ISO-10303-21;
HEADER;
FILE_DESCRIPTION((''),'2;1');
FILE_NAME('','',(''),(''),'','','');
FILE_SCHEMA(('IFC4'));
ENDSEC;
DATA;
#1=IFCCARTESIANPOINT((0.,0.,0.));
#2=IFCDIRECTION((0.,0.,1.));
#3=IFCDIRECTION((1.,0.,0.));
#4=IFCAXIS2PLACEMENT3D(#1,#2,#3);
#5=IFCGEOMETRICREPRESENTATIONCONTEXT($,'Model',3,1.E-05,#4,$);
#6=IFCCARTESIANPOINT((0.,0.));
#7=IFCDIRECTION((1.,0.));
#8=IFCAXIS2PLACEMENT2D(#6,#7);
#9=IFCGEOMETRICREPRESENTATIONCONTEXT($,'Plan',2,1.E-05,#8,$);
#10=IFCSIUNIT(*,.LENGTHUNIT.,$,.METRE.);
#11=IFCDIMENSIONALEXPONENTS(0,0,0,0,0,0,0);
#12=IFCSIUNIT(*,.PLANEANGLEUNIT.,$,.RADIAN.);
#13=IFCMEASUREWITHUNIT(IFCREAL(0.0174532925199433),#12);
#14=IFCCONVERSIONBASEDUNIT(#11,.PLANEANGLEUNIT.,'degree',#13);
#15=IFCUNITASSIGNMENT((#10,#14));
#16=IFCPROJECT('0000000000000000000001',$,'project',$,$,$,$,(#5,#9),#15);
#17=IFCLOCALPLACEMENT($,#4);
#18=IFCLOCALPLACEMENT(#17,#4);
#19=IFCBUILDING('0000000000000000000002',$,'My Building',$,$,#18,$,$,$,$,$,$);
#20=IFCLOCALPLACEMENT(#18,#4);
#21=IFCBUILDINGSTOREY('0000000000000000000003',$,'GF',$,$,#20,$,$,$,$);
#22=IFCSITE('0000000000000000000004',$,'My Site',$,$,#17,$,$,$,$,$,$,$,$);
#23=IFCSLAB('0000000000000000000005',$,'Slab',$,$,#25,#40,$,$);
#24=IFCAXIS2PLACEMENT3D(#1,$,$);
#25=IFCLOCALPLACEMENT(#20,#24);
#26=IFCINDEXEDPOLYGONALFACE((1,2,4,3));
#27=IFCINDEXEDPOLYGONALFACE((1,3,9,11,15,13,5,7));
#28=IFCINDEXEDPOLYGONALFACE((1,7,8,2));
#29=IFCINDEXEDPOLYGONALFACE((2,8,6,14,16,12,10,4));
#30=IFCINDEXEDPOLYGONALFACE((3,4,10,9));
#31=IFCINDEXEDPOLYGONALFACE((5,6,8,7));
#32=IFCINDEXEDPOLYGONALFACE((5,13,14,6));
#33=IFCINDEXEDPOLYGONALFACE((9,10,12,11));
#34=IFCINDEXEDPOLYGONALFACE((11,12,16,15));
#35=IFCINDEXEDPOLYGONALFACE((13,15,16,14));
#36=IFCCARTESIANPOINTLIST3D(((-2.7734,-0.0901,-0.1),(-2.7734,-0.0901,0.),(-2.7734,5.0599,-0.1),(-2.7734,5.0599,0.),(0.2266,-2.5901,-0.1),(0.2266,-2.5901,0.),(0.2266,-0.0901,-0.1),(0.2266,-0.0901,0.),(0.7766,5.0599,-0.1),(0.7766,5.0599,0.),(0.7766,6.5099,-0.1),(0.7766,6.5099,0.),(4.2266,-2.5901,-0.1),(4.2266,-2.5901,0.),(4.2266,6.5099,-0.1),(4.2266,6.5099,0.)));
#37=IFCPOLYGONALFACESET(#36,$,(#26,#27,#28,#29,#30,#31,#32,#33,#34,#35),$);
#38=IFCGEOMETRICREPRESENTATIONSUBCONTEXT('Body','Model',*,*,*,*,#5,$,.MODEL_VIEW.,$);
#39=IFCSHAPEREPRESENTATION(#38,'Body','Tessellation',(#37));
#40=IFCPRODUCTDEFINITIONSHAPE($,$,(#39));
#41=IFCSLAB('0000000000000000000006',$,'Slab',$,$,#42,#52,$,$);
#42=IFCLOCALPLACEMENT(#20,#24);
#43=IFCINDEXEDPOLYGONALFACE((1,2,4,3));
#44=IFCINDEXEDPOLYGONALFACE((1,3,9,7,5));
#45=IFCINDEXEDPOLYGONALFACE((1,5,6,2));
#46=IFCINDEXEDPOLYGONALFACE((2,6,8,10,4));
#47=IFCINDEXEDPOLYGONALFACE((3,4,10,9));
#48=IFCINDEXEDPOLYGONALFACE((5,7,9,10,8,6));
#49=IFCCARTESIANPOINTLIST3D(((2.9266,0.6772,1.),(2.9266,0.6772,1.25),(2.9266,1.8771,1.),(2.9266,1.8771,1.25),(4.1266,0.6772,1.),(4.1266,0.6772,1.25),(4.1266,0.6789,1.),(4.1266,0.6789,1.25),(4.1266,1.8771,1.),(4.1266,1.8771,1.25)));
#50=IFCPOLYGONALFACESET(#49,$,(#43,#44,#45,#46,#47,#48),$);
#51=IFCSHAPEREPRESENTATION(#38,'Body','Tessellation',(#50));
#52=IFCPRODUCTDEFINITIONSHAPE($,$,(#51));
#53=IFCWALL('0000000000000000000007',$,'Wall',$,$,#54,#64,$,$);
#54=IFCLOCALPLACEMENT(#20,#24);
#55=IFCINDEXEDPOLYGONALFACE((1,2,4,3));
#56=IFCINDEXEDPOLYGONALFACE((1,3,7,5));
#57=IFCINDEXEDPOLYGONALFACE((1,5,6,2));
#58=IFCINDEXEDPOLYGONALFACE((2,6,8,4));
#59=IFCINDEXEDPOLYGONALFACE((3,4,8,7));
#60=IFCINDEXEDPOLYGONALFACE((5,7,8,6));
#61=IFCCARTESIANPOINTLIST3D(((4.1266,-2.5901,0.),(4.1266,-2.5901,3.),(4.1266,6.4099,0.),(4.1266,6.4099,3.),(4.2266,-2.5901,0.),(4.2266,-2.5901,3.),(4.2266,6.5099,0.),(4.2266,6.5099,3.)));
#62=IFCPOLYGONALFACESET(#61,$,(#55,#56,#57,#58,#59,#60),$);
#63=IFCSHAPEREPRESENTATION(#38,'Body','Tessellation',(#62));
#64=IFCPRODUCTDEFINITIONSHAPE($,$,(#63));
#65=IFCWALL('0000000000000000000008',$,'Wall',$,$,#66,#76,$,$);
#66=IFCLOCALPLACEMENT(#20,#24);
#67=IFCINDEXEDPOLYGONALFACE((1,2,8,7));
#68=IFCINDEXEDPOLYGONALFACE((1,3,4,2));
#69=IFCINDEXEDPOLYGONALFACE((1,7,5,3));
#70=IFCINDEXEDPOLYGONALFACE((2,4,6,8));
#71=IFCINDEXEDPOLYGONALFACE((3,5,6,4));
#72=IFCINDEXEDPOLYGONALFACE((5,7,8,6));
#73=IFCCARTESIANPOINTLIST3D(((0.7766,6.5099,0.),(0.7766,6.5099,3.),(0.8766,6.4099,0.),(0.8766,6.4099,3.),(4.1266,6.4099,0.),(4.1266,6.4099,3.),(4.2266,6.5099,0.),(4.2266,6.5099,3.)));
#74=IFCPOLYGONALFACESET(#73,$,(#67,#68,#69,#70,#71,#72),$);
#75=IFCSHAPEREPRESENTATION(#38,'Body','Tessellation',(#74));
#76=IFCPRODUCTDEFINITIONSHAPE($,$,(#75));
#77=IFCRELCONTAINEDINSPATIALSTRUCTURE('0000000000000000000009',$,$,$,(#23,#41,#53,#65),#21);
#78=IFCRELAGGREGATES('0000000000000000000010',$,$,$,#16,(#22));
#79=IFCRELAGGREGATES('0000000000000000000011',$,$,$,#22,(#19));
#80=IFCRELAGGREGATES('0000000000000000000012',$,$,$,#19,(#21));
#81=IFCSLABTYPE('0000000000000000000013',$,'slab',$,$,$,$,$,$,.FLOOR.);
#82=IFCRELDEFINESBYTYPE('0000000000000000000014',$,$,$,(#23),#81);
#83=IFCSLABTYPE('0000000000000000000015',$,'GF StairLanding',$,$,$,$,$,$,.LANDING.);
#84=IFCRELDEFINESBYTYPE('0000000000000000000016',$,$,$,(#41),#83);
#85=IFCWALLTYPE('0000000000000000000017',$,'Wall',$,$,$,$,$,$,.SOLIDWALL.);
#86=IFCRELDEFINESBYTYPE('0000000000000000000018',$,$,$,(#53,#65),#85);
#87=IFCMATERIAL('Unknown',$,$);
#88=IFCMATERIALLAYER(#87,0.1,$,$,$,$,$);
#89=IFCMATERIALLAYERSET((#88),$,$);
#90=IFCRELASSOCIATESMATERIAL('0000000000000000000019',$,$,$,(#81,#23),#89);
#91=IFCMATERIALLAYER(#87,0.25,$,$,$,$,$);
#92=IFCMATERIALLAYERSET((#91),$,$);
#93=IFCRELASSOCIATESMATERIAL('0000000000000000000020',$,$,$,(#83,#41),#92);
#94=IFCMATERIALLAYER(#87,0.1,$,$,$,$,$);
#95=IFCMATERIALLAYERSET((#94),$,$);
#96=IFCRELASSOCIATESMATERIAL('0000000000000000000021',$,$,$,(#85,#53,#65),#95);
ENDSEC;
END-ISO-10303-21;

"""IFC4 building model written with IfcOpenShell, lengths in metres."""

from ifc_helpers import new_model, entity, si_unit, converted_unit, frame, origin_with_axes, origin_2d_with_axis, place, context, subcontext, project, spatial, line, indexed_curve, outline, extrude, material, layer, layer_set, layer_usage, type_object, element, save


model = new_model("IFC4")

# Units and contexts
model_context = context("Model", 3, precision=1e-05, world=origin_with_axes())
plan_context = context("Plan", 2, precision=1e-05, world=origin_2d_with_axis())
body_context_1 = subcontext(model_context, "Body", "Model", "MODEL_VIEW")
ifc_project = project(units=[si_unit("LENGTHUNIT", "METRE"), converted_unit("PLANEANGLEUNIT", "degree", entity("IfcReal", 0.0174532925199433), si_unit("PLANEANGLEUNIT", "RADIAN"), dimensions=[0, 0, 0, 0, 0, 0, 0])], contexts=[model_context, plan_context])

# Site, building, storey
site_placement = place(None, origin_with_axes())
site = spatial("IfcSite", under=ifc_project, at=site_placement, Name="My Site")
building_placement = place(site_placement, origin_with_axes())
building = spatial("IfcBuilding", under=site, at=building_placement, Name="My Building")
storey_placement = place(building_placement, origin_with_axes())
storey = spatial("IfcBuildingStorey", under=building, at=storey_placement, Name="GF")

# Slabs
ifc_material_1 = material(Name="Unknown")
ifc_layer_1 = layer(ifc_material_1, 0.1)
ifc_layer_set_1 = layer_set([ifc_layer_1])
ifc_layer_usage_1 = layer_usage(ifc_layer_set_1, "AXIS3", "POSITIVE", -0.1)
slab_type_1 = type_object("IfcSlabType", Name="slab", PredefinedType="FLOOR", material=ifc_layer_set_1)
slab_1_placement = place(storey_placement, frame((4.2266, -2.5901, 0.0), z_axis=(0.0, 0.0, 1.0), x_axis=(1.0, 0.0, 0.0)))
element("IfcSlab", 1, at=slab_1_placement, inside=storey, type_object=slab_type_1, material=ifc_layer_usage_1, Name="Slab", context=body_context_1, shape_type="SweptSolid", body=[
    extrude(outline(indexed_curve([(0.0, 0.0), (0.0, 9.1), (-3.45, 9.1), (-3.45, 7.65), (-7.0, 7.65), (-7.0, 2.5), (-4.0, 2.5), (-4.0, 0.0), (0.0, 0.0)])), frame((0.0, 0.0, -0.1), z_axis=(0.0, 0.0, 1.0), x_axis=(1.0, 0.0, 0.0)), (0.0, 0.0, 1.0), 0.1),
])
ifc_layer_2 = layer(ifc_material_1, 0.25)
ifc_layer_set_2 = layer_set([ifc_layer_2])
ifc_layer_usage_2 = layer_usage(ifc_layer_set_2, "AXIS3", "POSITIVE", -0.1)
slab_type_2 = type_object("IfcSlabType", Name="GF StairLanding", PredefinedType="LANDING", material=ifc_layer_set_2)
slab_2_placement = place(storey_placement, frame((2.9266, 1.8771, 1.1), z_axis=(0.0, 0.0, 1.0), x_axis=(1.0, 0.0, 0.0)))
element("IfcSlab", 2, at=slab_2_placement, inside=storey, type_object=slab_type_2, material=ifc_layer_usage_2, Name="Slab", context=body_context_1, shape_type="SweptSolid", body=[
    extrude(outline(indexed_curve([(0.0, 0.0), (1.1999, 0.0), (1.1999, -1.1982), (1.1999, -1.1999), (0.0, -1.1999), (0.0, 0.0)])), frame((0.0, 0.0, -0.1), z_axis=(0.0, 0.0, 1.0), x_axis=(1.0, 0.0, 0.0)), (0.0, 0.0, 1.0), 0.25),
])

# Shared definitions
ifc_layer_3 = layer(ifc_material_1, 0.1)
ifc_layer_set_3 = layer_set([ifc_layer_3])
wall_type = type_object("IfcWallType", Name="Wall", PredefinedType="SOLIDWALL", material=ifc_layer_set_3)

# Walls
ifc_layer_usage_3 = layer_usage(ifc_layer_set_3, "AXIS2", "POSITIVE", 0.0)
wall_1_placement = place(storey_placement, frame((4.2266, -2.5901, 0.0), z_axis=(0.0, 0.0, 1.0), x_axis=(0.0, 1.0, 0.0)))
element("IfcWall", 3, at=wall_1_placement, inside=storey, type_object=wall_type, material=ifc_layer_usage_3, Name="Wall", context=body_context_1, shape_type="SweptSolid", body=[
    extrude(outline(indexed_curve([(0.0, 0.0), (0.0, 0.1), (9.0, 0.1), (9.1, 0.0)], segments=[line(1, 2, 3, 4, 1)])), origin_with_axes(), (0.0, 0.0, 1.0), 3.0),
])
ifc_layer_usage_4 = layer_usage(ifc_layer_set_3, "AXIS2", "POSITIVE", 0.0)
wall_2_placement = place(storey_placement, frame((4.2266, 6.5099, 0.0), z_axis=(0.0, 0.0, 1.0), x_axis=(-1.0, 0.0, 0.0)))
element("IfcWall", 4, at=wall_2_placement, inside=storey, type_object=wall_type, material=ifc_layer_usage_4, Name="Wall", context=body_context_1, shape_type="SweptSolid", body=[
    extrude(outline(indexed_curve([(0.0, 0.0), (0.1, 0.1), (3.35, 0.1), (3.45, 0.0)], segments=[line(1, 2, 3, 4, 1)])), origin_with_axes(), (0.0, 0.0, 1.0), 3.0),
])

save(model, "model.ifc")
